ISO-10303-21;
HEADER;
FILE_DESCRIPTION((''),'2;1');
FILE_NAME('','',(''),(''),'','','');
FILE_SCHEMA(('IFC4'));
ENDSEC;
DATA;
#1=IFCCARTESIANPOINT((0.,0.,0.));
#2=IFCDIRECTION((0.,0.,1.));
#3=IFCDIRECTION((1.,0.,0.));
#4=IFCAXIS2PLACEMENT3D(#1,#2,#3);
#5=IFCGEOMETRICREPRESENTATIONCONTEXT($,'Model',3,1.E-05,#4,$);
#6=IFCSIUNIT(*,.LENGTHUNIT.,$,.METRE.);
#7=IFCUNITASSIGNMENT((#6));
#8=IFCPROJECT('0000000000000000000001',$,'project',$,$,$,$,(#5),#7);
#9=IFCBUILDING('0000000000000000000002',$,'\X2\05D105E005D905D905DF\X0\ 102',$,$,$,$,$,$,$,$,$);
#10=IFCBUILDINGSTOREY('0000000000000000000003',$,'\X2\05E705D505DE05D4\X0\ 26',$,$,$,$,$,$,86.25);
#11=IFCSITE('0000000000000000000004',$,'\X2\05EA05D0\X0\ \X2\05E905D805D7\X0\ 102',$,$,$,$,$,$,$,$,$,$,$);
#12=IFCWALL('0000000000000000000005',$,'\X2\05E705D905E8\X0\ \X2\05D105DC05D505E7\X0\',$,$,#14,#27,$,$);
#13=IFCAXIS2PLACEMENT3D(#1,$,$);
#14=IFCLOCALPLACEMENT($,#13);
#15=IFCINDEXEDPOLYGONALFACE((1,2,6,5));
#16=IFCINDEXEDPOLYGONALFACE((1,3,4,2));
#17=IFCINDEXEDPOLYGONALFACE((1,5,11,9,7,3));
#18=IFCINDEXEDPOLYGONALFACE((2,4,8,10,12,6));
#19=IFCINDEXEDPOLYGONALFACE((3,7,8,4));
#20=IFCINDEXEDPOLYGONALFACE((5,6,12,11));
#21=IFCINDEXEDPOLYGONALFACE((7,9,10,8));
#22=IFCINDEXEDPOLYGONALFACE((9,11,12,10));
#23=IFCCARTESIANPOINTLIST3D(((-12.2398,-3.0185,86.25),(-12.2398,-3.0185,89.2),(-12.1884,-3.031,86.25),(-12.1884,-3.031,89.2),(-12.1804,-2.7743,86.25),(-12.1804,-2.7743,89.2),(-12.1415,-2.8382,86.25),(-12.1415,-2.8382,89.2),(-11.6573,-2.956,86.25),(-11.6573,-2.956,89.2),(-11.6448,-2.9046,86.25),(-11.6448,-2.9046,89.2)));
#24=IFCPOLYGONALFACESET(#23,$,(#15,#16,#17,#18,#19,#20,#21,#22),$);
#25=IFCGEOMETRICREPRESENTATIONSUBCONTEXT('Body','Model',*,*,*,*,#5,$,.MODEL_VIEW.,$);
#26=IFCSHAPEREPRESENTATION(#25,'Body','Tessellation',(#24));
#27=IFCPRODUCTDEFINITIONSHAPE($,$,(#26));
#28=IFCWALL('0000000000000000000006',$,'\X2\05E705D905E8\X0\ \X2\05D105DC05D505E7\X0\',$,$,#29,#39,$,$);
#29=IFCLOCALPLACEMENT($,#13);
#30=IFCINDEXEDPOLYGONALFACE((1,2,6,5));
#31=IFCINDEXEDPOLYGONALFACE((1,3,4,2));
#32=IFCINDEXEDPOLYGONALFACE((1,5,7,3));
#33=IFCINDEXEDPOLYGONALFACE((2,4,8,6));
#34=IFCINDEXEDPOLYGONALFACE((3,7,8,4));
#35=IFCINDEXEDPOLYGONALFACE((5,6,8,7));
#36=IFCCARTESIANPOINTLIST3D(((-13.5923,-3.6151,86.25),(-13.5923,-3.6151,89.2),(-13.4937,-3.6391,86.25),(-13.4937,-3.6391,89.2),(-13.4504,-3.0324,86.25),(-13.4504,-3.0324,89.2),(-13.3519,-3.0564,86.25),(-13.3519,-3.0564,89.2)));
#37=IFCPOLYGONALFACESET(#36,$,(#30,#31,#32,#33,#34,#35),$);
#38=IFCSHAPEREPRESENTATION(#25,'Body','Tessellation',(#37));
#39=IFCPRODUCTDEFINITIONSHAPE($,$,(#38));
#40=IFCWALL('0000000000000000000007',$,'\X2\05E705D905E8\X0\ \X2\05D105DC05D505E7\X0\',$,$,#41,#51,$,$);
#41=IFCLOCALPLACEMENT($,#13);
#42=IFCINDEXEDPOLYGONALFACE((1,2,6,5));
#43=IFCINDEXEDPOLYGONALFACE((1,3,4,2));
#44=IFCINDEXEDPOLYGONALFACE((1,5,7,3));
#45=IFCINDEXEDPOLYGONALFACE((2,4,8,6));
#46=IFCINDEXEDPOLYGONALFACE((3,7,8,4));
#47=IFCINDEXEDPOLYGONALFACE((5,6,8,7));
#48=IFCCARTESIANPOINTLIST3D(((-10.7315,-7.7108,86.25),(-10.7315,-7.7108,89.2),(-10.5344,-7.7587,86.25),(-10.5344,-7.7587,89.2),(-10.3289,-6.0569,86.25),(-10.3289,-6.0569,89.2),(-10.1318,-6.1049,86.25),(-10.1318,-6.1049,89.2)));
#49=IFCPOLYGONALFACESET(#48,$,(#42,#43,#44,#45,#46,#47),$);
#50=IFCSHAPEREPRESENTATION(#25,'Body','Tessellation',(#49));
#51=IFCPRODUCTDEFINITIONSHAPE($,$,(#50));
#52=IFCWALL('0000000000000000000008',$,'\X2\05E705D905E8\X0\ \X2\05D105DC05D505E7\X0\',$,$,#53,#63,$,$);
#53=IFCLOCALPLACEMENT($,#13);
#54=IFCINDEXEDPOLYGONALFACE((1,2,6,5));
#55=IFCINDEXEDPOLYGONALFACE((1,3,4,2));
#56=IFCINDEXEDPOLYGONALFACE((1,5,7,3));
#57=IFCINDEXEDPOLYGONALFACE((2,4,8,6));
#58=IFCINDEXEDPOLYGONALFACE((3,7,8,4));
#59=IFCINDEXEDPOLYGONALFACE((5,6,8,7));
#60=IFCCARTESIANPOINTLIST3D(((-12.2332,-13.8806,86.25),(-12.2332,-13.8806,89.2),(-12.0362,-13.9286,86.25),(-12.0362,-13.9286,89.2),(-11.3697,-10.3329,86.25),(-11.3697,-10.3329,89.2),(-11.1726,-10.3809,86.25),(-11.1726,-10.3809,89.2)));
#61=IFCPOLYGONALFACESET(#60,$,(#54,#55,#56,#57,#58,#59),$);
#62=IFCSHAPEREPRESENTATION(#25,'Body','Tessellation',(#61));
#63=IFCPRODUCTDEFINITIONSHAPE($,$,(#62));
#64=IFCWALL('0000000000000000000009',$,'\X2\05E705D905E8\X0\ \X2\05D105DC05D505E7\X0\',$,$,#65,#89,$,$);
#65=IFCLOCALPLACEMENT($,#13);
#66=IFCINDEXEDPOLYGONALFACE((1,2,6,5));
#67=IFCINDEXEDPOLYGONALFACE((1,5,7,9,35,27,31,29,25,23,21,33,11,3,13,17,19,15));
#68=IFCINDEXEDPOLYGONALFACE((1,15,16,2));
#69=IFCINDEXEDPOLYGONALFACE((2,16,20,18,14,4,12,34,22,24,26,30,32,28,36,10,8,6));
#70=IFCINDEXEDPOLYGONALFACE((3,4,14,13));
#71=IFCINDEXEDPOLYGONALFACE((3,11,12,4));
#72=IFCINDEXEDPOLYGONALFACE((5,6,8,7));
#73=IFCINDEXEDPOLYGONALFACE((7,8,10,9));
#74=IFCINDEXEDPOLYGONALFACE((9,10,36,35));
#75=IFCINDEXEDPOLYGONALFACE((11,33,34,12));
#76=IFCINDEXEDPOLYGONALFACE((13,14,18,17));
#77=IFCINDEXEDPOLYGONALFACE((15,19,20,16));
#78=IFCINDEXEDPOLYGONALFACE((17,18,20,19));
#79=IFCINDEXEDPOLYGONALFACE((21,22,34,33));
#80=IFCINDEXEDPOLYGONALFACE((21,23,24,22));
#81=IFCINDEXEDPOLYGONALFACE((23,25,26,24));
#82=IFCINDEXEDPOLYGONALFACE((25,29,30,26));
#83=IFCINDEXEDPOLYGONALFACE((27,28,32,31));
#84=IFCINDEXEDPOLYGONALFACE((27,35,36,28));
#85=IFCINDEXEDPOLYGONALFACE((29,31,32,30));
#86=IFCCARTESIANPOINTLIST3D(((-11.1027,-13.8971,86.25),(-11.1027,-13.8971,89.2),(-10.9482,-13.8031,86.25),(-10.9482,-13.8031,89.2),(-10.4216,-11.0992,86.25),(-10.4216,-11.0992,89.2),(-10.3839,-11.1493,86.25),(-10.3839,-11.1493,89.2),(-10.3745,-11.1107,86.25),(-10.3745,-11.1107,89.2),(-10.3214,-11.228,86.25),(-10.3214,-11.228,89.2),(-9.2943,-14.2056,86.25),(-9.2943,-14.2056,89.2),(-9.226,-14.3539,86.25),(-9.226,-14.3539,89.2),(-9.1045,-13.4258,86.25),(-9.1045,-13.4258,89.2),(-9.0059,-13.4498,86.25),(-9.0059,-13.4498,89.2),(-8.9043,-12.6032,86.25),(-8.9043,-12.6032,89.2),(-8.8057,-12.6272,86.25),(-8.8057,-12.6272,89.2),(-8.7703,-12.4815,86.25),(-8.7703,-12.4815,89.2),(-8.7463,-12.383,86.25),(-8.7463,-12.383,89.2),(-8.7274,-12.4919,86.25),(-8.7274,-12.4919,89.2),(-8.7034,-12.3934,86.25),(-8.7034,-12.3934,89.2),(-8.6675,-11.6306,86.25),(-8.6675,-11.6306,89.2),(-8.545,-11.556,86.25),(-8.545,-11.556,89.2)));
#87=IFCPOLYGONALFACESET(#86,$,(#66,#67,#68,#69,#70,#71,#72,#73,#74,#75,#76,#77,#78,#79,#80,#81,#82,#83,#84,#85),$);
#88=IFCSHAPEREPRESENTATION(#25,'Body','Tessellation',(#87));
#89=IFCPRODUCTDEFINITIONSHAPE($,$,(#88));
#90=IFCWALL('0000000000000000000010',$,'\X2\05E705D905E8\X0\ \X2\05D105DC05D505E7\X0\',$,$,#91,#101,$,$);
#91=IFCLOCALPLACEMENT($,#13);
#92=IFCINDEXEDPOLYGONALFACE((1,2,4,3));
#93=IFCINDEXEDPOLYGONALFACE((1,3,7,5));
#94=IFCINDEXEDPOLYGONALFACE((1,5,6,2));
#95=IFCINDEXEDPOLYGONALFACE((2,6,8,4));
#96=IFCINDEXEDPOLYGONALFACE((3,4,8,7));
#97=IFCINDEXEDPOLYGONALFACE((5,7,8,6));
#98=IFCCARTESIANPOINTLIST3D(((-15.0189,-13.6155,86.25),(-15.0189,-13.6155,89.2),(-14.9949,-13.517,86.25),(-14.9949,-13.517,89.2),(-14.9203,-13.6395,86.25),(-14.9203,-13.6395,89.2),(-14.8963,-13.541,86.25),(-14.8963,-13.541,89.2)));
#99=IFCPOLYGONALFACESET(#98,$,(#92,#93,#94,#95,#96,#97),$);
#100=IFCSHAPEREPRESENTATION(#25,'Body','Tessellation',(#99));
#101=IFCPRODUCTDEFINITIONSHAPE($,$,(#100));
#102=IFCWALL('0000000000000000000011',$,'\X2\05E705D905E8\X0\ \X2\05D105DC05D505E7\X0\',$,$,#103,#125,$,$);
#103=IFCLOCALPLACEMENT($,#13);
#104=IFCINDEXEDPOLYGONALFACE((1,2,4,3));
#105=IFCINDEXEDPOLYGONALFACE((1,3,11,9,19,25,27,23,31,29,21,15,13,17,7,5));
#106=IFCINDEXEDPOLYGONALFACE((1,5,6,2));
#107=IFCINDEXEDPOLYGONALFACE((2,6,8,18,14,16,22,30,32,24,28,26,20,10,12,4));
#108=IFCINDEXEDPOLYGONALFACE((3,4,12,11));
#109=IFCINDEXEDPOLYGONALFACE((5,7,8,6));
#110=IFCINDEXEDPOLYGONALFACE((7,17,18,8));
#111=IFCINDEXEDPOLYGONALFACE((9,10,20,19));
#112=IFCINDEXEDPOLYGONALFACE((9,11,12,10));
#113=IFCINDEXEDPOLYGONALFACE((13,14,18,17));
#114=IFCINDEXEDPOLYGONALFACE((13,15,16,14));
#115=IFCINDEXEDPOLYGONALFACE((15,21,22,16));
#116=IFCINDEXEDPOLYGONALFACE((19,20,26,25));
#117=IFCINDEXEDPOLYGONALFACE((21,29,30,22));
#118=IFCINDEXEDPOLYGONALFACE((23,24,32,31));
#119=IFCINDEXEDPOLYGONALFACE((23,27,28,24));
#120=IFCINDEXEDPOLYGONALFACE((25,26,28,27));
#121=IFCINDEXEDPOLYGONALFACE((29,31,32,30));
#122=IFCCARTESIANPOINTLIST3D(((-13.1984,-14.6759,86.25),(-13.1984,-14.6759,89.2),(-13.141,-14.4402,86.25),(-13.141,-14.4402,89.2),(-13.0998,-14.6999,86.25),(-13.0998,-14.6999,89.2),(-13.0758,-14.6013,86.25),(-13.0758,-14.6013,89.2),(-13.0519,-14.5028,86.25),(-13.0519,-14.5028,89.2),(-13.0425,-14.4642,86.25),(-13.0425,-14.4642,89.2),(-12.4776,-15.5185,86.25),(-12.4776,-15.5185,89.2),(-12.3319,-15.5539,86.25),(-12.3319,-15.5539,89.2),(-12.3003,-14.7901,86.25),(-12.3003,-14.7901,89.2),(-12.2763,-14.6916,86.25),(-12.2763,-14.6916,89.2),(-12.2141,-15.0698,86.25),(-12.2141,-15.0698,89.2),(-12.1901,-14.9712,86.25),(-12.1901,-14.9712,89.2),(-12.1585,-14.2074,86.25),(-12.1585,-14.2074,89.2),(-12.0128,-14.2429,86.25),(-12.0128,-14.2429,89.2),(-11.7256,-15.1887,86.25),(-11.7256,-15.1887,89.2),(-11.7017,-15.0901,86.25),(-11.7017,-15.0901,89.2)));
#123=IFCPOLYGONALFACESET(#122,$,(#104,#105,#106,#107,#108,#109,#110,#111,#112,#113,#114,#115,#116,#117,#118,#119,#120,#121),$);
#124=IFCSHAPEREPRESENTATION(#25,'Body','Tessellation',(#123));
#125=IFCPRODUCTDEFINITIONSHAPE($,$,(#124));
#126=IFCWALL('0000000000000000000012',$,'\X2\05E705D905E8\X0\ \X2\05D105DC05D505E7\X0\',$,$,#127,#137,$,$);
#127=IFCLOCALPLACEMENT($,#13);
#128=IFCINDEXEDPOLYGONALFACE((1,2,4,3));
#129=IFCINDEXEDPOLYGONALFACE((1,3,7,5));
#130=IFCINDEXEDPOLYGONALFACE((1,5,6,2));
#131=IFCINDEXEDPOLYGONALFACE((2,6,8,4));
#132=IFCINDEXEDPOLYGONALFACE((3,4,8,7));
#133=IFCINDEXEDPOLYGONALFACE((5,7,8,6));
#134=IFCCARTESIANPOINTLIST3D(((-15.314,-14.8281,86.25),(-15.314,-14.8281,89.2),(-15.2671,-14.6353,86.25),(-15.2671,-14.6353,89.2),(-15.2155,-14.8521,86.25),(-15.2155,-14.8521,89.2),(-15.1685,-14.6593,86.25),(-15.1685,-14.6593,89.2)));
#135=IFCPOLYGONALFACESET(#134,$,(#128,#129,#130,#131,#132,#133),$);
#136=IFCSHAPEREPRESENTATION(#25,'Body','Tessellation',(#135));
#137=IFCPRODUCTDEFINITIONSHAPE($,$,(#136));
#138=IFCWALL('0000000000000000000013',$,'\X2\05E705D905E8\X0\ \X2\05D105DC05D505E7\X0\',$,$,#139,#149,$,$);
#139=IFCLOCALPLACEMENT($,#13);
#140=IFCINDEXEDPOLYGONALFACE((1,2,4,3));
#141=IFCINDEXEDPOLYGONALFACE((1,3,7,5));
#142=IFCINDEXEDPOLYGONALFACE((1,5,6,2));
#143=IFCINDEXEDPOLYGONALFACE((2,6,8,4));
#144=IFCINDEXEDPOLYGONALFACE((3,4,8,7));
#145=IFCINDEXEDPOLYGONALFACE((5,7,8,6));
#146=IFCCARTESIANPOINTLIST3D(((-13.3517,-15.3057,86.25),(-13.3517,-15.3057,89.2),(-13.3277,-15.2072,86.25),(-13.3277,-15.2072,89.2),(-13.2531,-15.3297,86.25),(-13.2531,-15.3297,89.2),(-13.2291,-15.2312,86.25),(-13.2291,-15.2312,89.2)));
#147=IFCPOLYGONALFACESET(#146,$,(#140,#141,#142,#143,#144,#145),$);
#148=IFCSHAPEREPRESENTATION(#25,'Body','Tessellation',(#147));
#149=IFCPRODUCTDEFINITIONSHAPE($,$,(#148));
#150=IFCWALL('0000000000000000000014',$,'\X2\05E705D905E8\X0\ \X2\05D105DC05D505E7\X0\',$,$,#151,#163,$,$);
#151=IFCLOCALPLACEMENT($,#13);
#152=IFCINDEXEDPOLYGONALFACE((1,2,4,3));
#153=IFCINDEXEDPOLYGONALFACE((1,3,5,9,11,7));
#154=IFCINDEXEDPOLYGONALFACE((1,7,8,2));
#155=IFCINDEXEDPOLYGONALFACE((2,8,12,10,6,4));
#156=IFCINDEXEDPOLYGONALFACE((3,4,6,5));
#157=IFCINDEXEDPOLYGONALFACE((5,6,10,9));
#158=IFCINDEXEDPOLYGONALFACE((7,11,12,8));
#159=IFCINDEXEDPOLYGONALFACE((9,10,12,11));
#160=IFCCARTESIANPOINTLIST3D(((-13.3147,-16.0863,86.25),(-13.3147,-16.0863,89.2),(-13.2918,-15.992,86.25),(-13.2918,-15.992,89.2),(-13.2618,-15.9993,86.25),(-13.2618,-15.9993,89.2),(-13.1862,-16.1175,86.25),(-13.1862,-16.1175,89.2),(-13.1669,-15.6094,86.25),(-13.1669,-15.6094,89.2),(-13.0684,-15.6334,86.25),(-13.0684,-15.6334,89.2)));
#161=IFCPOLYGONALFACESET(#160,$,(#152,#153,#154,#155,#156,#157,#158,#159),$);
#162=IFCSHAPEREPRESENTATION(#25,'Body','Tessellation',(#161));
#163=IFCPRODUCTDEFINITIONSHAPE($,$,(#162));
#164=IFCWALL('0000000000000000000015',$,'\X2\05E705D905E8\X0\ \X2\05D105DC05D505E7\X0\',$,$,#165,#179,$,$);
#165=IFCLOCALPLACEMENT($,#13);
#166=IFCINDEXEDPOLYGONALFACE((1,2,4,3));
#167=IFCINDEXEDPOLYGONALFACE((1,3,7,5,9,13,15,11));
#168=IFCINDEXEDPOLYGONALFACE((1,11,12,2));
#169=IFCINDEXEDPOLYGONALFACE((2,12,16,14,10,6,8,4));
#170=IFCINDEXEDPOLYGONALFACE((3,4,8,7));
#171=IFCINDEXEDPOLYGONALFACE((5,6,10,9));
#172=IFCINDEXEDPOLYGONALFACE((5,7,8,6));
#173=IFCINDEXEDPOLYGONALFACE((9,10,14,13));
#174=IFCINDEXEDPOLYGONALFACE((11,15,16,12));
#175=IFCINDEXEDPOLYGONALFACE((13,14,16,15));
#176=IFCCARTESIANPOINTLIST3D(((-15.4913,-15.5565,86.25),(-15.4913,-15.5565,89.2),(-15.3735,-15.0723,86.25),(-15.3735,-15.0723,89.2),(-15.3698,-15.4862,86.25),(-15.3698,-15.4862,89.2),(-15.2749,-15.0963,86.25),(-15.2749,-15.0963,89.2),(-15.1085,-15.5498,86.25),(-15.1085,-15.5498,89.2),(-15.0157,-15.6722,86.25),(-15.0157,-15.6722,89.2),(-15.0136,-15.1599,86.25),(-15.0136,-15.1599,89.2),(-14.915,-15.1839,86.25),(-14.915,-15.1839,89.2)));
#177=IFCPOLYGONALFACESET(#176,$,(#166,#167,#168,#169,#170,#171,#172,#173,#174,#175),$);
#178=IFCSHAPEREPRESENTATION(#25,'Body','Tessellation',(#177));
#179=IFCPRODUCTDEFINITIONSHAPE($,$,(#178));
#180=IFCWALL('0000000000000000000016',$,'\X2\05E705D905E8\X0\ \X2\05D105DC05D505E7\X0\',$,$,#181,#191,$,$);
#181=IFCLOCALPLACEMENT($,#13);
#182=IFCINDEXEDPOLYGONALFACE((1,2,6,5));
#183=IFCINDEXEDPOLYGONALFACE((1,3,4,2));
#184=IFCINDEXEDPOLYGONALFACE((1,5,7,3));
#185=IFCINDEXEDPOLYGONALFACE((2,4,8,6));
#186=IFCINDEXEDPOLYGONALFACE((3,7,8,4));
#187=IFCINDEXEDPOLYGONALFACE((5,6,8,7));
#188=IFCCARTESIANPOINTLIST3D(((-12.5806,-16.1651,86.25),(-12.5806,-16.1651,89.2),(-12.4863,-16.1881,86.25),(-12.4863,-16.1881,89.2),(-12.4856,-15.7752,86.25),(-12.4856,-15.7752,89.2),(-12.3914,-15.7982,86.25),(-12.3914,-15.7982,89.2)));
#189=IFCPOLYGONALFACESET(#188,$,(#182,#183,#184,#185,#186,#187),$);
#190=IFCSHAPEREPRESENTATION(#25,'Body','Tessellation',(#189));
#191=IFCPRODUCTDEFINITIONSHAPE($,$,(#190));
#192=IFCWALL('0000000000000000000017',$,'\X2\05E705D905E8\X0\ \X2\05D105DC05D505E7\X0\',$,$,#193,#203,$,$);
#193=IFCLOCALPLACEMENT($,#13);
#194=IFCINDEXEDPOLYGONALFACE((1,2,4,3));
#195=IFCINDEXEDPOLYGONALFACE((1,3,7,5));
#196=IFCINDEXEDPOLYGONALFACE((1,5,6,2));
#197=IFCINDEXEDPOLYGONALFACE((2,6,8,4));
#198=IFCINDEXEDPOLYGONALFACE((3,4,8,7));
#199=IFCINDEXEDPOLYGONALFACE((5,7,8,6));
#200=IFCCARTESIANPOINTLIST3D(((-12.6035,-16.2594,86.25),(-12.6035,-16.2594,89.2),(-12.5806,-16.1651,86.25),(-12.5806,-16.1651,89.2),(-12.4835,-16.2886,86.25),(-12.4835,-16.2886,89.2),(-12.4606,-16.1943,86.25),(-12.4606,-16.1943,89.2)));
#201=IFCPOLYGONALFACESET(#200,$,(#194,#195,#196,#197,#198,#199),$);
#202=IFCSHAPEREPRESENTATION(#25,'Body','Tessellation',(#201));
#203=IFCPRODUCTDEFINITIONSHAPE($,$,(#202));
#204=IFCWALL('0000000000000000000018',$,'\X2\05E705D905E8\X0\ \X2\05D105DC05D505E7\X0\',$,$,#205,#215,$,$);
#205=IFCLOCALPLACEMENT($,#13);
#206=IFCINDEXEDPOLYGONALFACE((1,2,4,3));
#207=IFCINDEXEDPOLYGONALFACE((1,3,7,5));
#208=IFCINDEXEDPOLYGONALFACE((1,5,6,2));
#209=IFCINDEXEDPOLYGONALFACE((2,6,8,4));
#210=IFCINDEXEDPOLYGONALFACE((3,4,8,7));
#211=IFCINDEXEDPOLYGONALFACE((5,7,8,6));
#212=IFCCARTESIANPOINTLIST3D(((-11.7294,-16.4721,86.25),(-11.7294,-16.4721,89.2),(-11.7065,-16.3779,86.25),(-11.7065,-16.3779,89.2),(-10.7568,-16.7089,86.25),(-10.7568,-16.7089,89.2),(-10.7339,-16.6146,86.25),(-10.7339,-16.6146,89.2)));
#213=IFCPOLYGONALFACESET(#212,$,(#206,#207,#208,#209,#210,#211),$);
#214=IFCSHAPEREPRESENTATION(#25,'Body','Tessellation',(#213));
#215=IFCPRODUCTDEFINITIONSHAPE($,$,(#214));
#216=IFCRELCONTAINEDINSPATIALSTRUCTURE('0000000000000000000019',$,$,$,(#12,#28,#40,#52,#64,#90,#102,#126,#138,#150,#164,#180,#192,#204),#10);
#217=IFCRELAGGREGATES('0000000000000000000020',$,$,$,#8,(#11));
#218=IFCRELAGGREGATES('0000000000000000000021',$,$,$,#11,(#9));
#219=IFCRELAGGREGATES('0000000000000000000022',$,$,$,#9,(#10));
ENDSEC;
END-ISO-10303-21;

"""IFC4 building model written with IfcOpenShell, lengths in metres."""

from ifc_helpers import new_model, si_unit, frame, origin_with_axes, context, subcontext, project, spatial, polyline, outline, extrude, element, save


model = new_model("IFC4")

# Units and contexts
model_context = context("Model", 3, precision=1e-05, world=origin_with_axes())
body_context = subcontext(model_context, "Body", "Model", "MODEL_VIEW")
ifc_project = project(units=[si_unit("LENGTHUNIT", "METRE")], contexts=[model_context])

# Site, building, storey
site = spatial("IfcSite", under=ifc_project, Name="תא שטח 102")
building = spatial("IfcBuilding", under=site, Name="בניין 102")
storey = spatial("IfcBuildingStorey", under=building, Name="קומה 26", Elevation=86.25)

# Walls
element("IfcWall", 1, inside=storey, Name="קיר בלוק", context=body_context, shape_type="SweptSolid", body=[
    extrude(outline(polyline([(-12.1415, -2.8382), (-11.6573, -2.956), (-11.6448, -2.9046), (-12.1804, -2.7743), (-12.2398, -3.0185), (-12.1884, -3.031), (-12.1415, -2.8382)])), frame((0.0, 0.0, 86.25)), (0.0, 0.0, 1.0), 2.95),
])
element("IfcWall", 2, inside=storey, Name="קיר בלוק", context=body_context, shape_type="SweptSolid", body=[
    extrude(outline(polyline([(-13.4504, -3.0324), (-13.5923, -3.6151), (-13.4937, -3.6391), (-13.3519, -3.0564), (-13.4504, -3.0324)])), frame((0.0, 0.0, 86.25)), (0.0, 0.0, 1.0), 2.95),
])
element("IfcWall", 3, inside=storey, Name="קיר בלוק", context=body_context, shape_type="SweptSolid", body=[
    extrude(outline(polyline([(-10.7315, -7.7108), (-10.5344, -7.7587), (-10.1318, -6.1049), (-10.3289, -6.0569), (-10.7315, -7.7108)])), frame((0.0, 0.0, 86.25)), (0.0, 0.0, 1.0), 2.95),
])
element("IfcWall", 4, inside=storey, Name="קיר בלוק", context=body_context, shape_type="SweptSolid", body=[
    extrude(outline(polyline([(-12.2332, -13.8806), (-12.0362, -13.9286), (-11.1726, -10.3809), (-11.3697, -10.3329), (-12.2332, -13.8806)])), frame((0.0, 0.0, 86.25)), (0.0, 0.0, 1.0), 2.95),
])
element("IfcWall", 5, inside=storey, Name="קיר בלוק", context=body_context, shape_type="SweptSolid", body=[
    extrude(outline(polyline([(-11.1027, -13.8971), (-9.226, -14.3539), (-9.0059, -13.4498), (-9.1045, -13.4258), (-9.2943, -14.2056), (-10.9482, -13.8031), (-10.3214, -11.228), (-8.6675, -11.6306), (-8.9043, -12.6032), (-8.8057, -12.6272), (-8.7703, -12.4815), (-8.7274, -12.4919), (-8.7034, -12.3934), (-8.7463, -12.383), (-8.545, -11.556), (-10.3745, -11.1107), (-10.3839, -11.1493), (-10.4216, -11.0992), (-11.1027, -13.8971)])), frame((0.0, 0.0, 86.25)), (0.0, 0.0, 1.0), 2.95),
])
element("IfcWall", 6, inside=storey, Name="קיר בלוק", context=body_context, shape_type="SweptSolid", body=[
    extrude(outline(polyline([(-14.9949, -13.517), (-15.0189, -13.6155), (-14.9203, -13.6395), (-14.8963, -13.541), (-14.9949, -13.517)])), frame((0.0, 0.0, 86.25)), (0.0, 0.0, 1.0), 2.95),
])
element("IfcWall", 7, inside=storey, Name="קיר בלוק", context=body_context, shape_type="SweptSolid", body=[
    extrude(outline(polyline([(-13.0998, -14.6999), (-13.0758, -14.6013), (-12.3003, -14.7901), (-12.4776, -15.5185), (-12.3319, -15.5539), (-12.2141, -15.0698), (-11.7256, -15.1887), (-11.7017, -15.0901), (-12.1901, -14.9712), (-12.0128, -14.2429), (-12.1585, -14.2074), (-12.2763, -14.6916), (-13.0519, -14.5028), (-13.0425, -14.4642), (-13.141, -14.4402), (-13.1984, -14.6759), (-13.0998, -14.6999)])), frame((0.0, 0.0, 86.25)), (0.0, 0.0, 1.0), 2.95),
])
element("IfcWall", 8, inside=storey, Name="קיר בלוק", context=body_context, shape_type="SweptSolid", body=[
    extrude(outline(polyline([(-15.1685, -14.6593), (-15.2671, -14.6353), (-15.314, -14.8281), (-15.2155, -14.8521), (-15.1685, -14.6593)])), frame((0.0, 0.0, 86.25)), (0.0, 0.0, 1.0), 2.95),
])
element("IfcWall", 9, inside=storey, Name="קיר בלוק", context=body_context, shape_type="SweptSolid", body=[
    extrude(outline(polyline([(-13.3277, -15.2072), (-13.3517, -15.3057), (-13.2531, -15.3297), (-13.2291, -15.2312), (-13.3277, -15.2072)])), frame((0.0, 0.0, 86.25)), (0.0, 0.0, 1.0), 2.95),
])
element("IfcWall", 10, inside=storey, Name="קיר בלוק", context=body_context, shape_type="SweptSolid", body=[
    extrude(outline(polyline([(-13.3147, -16.0863), (-13.1862, -16.1175), (-13.0684, -15.6334), (-13.1669, -15.6094), (-13.2618, -15.9993), (-13.2918, -15.992), (-13.3147, -16.0863)])), frame((0.0, 0.0, 86.25)), (0.0, 0.0, 1.0), 2.95),
])
element("IfcWall", 11, inside=storey, Name="קיר בלוק", context=body_context, shape_type="SweptSolid", body=[
    extrude(outline(polyline([(-15.3735, -15.0723), (-15.4913, -15.5565), (-15.0157, -15.6722), (-14.915, -15.1839), (-15.0136, -15.1599), (-15.1085, -15.5498), (-15.3698, -15.4862), (-15.2749, -15.0963), (-15.3735, -15.0723)])), frame((0.0, 0.0, 86.25)), (0.0, 0.0, 1.0), 2.95),
])
element("IfcWall", 12, inside=storey, Name="קיר בלוק", context=body_context, shape_type="SweptSolid", body=[
    extrude(outline(polyline([(-12.4856, -15.7752), (-12.5806, -16.1651), (-12.4863, -16.1881), (-12.3914, -15.7982), (-12.4856, -15.7752)])), frame((0.0, 0.0, 86.25)), (0.0, 0.0, 1.0), 2.95),
])
element("IfcWall", 13, inside=storey, Name="קיר בלוק", context=body_context, shape_type="SweptSolid", body=[
    extrude(outline(polyline([(-12.4835, -16.2886), (-12.4606, -16.1943), (-12.5806, -16.1651), (-12.6035, -16.2594), (-12.4835, -16.2886)])), frame((0.0, 0.0, 86.25)), (0.0, 0.0, 1.0), 2.95),
])
element("IfcWall", 14, inside=storey, Name="קיר בלוק", context=body_context, shape_type="SweptSolid", body=[
    extrude(outline(polyline([(-11.7294, -16.4721), (-10.7568, -16.7089), (-10.7339, -16.6146), (-11.7065, -16.3779), (-11.7294, -16.4721)])), frame((0.0, 0.0, 86.25)), (0.0, 0.0, 1.0), 2.95),
])

save(model, "model.ifc")
